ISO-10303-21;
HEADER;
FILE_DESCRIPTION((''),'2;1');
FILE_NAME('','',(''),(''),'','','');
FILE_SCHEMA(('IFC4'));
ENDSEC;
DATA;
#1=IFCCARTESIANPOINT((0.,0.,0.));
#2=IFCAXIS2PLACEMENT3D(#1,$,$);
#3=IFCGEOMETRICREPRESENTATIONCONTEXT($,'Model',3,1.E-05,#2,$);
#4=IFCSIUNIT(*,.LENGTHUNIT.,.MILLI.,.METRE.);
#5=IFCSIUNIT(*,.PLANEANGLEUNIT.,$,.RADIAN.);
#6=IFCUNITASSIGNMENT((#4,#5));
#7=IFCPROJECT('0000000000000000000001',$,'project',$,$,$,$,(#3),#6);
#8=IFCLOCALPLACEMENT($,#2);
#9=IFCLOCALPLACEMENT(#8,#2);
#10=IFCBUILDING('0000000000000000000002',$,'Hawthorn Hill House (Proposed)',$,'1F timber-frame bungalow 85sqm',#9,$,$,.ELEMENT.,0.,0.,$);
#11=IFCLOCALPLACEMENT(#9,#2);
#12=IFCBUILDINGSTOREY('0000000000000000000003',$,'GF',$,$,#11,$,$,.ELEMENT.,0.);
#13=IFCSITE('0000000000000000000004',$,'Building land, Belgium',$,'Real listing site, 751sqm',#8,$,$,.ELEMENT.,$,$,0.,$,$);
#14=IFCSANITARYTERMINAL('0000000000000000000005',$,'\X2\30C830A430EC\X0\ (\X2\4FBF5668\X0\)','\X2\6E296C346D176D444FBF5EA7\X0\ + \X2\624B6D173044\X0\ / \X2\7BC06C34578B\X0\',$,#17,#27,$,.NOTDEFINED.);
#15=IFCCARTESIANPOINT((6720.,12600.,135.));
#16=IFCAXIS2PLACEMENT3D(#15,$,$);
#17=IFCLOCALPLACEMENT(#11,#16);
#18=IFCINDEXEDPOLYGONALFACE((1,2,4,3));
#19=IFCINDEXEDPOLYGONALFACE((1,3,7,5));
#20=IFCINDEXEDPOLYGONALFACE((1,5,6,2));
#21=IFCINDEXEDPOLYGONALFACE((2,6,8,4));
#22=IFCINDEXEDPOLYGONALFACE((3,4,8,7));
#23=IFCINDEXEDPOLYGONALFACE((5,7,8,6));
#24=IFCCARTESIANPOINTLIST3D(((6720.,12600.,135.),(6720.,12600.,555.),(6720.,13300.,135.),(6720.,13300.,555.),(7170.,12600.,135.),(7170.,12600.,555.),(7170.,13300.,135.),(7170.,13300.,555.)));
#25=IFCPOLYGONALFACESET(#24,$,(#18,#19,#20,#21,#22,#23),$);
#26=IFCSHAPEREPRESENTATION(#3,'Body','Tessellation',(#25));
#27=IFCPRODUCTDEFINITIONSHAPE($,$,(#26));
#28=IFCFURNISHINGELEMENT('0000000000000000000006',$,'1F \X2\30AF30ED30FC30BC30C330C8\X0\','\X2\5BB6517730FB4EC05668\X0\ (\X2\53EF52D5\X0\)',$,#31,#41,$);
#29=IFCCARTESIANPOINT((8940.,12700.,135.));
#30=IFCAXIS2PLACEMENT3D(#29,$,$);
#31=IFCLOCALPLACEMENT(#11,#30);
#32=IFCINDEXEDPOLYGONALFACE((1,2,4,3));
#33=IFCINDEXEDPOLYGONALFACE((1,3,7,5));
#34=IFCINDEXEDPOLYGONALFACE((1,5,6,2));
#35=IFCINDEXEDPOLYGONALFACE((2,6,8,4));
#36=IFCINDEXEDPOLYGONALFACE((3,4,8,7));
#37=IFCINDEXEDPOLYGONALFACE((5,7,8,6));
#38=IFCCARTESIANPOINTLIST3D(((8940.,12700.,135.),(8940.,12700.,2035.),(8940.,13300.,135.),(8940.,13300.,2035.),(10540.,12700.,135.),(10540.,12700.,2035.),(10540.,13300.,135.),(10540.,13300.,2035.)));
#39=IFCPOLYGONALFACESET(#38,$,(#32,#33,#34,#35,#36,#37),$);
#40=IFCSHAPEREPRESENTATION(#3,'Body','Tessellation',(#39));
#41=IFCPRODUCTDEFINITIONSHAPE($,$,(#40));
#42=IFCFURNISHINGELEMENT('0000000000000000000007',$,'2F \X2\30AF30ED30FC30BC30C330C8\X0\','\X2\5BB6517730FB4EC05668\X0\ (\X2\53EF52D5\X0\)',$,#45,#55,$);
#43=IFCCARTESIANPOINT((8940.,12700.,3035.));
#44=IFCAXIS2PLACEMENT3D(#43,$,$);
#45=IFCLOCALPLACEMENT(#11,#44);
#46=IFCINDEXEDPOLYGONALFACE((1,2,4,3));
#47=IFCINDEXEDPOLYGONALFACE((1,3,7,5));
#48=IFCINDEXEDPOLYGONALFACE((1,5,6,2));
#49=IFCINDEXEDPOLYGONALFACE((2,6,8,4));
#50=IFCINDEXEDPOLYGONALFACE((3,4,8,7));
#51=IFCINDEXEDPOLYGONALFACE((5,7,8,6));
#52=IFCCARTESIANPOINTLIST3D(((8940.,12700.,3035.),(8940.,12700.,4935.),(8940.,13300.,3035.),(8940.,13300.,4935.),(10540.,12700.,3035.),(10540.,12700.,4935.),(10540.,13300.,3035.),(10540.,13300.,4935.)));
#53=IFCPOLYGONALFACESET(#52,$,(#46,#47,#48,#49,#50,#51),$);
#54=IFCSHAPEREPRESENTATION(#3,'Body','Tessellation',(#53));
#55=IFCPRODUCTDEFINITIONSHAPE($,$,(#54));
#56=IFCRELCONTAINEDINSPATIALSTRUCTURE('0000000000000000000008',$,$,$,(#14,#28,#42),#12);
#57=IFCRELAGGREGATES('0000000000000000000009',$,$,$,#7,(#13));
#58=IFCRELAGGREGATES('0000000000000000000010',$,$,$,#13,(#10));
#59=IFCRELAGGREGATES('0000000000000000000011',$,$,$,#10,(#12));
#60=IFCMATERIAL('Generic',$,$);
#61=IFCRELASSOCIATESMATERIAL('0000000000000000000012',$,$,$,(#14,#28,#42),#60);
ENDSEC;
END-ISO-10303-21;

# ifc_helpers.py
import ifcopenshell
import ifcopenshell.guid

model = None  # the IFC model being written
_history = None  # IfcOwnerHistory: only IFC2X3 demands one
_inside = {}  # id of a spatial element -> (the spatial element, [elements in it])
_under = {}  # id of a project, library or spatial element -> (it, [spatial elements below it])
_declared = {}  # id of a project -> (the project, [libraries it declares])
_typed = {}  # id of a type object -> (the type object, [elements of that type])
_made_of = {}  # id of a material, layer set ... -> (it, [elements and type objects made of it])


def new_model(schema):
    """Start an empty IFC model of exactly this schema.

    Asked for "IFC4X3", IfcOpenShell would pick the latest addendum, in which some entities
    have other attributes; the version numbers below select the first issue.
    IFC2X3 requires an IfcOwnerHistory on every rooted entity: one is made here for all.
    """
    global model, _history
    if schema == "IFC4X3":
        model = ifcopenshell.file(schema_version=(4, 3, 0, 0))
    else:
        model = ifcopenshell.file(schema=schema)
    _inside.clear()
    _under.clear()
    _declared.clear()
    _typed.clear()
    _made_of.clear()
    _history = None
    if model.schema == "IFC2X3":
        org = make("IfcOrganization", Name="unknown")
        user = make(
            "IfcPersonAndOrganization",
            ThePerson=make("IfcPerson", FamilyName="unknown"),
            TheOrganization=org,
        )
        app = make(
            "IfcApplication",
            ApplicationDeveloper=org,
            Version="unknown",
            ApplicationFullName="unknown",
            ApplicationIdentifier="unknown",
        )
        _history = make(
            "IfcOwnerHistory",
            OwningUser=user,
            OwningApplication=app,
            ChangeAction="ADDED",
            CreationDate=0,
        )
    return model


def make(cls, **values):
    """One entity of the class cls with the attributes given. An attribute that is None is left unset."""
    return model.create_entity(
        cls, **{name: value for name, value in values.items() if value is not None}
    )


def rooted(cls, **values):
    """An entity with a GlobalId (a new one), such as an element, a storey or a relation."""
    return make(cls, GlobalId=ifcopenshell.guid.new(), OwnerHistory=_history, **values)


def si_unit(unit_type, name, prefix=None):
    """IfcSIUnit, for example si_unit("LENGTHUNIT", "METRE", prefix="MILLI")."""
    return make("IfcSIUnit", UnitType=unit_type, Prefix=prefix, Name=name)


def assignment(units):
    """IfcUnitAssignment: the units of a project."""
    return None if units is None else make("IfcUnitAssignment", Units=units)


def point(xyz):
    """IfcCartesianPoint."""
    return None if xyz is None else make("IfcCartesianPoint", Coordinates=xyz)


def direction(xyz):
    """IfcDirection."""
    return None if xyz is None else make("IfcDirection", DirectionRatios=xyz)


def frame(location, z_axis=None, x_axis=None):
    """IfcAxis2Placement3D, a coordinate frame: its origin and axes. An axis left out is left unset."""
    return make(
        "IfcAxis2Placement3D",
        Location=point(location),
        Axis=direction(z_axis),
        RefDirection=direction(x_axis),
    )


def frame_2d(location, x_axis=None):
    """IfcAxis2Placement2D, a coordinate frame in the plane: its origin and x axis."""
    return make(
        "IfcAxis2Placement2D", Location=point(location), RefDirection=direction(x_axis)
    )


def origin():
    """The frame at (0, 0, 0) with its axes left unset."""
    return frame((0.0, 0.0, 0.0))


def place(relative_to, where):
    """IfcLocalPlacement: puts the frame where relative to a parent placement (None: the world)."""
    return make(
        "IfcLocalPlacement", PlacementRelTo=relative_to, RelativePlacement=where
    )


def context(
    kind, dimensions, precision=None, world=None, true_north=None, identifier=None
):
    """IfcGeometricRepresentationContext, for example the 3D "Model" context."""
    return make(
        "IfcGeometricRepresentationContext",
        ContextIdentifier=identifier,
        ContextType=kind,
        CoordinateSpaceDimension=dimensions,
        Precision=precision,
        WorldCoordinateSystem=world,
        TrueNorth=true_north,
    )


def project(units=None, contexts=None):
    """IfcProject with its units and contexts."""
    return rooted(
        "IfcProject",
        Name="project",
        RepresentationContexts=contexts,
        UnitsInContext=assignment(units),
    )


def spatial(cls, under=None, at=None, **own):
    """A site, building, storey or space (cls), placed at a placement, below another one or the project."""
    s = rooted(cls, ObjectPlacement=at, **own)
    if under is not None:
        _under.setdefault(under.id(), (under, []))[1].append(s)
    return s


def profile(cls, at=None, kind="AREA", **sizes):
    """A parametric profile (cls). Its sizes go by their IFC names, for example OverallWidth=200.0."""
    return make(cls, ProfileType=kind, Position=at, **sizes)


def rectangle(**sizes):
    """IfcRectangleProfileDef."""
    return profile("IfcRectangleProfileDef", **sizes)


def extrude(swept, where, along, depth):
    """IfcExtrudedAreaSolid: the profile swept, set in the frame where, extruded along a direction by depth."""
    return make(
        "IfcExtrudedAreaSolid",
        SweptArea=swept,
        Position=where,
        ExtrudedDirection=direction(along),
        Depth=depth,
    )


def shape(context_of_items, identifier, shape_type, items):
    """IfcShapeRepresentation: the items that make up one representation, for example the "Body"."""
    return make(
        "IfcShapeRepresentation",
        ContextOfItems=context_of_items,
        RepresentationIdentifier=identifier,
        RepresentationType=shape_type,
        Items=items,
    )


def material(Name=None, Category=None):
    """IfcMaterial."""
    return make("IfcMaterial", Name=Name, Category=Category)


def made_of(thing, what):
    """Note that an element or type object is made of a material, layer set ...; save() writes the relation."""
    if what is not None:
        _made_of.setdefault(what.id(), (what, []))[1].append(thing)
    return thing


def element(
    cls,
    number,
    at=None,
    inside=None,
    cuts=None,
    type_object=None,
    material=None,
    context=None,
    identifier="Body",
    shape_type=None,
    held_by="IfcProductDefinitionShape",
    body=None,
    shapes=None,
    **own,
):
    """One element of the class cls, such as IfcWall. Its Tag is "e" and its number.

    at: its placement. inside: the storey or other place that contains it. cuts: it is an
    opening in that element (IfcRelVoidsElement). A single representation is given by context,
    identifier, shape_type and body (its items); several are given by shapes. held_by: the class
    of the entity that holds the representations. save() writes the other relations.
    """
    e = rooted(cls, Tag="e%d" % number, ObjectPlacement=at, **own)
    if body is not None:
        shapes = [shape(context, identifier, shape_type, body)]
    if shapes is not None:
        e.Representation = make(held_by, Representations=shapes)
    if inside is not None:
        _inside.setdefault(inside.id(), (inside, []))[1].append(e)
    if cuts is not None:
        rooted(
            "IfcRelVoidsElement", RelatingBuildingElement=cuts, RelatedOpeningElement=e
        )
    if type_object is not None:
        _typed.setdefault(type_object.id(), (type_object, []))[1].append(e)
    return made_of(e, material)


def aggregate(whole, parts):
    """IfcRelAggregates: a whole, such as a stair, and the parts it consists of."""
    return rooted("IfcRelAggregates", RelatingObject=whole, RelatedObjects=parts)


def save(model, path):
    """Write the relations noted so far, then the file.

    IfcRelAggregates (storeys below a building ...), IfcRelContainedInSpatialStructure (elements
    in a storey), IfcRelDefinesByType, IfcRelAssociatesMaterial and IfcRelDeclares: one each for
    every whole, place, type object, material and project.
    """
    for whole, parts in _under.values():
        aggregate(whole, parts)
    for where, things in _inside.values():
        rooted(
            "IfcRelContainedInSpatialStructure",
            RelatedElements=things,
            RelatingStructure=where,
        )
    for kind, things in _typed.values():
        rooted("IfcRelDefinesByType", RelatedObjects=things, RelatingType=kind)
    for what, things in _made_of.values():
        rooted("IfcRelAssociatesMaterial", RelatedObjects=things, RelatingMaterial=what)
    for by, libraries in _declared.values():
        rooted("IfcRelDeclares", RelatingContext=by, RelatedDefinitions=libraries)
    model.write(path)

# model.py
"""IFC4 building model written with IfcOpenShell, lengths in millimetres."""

from ifc_helpers import new_model, si_unit, frame, frame_2d, origin, place, context, project, spatial, rectangle, extrude, material, element, save


model = new_model("IFC4")

# Units and contexts
model_context = context("Model", 3, precision=1e-05, world=origin())
ifc_project = project(units=[si_unit("LENGTHUNIT", "METRE", prefix="MILLI"), si_unit("PLANEANGLEUNIT", "RADIAN")], contexts=[model_context])

# Site, building, storey
site_placement = place(None, origin())
site = spatial("IfcSite", under=ifc_project, at=site_placement, Name="Building land, Belgium", ObjectType="Real listing site, 751sqm", CompositionType="ELEMENT", RefElevation=0.0)
building_placement = place(site_placement, origin())
building = spatial("IfcBuilding", under=site, at=building_placement, Name="Hawthorn Hill House (Proposed)", ObjectType="1F timber-frame bungalow 85sqm", CompositionType="ELEMENT", ElevationOfRefHeight=0.0, ElevationOfTerrain=0.0)
storey_placement = place(building_placement, origin())
storey = spatial("IfcBuildingStorey", under=building, at=storey_placement, Name="GF", CompositionType="ELEMENT", Elevation=0.0)

# Sanitary terminal
ifc_material_1 = material(Name="Generic")
sanitary_terminal_1_placement = place(storey_placement, frame((6720.0, 12600.0, 135.0)))
element("IfcSanitaryTerminal", 1, at=sanitary_terminal_1_placement, inside=storey, material=ifc_material_1, Name="トイレ (便器)", Description="温水洗浄便座 + 手洗い / 節水型", PredefinedType="NOTDEFINED", context=model_context, shape_type="SweptSolid", body=[
    extrude(rectangle(XDim=450.0, YDim=700.0, at=frame_2d((225.0, 350.0))), frame((6720.0, 12600.0, 135.0)), (0.0, 0.0, 1.0), 420.0),
])

# Furnishing elements
furnishing_1_placement = place(storey_placement, frame((8940.0, 12700.0, 135.0)))
element("IfcFurnishingElement", 2, at=furnishing_1_placement, inside=storey, material=ifc_material_1, Name="1F クローゼット", Description="家具・什器 (可動)", context=model_context, shape_type="SweptSolid", body=[
    extrude(rectangle(XDim=1600.0, YDim=600.0, at=frame_2d((800.0, 300.0))), frame((8940.0, 12700.0, 135.0)), (0.0, 0.0, 1.0), 1900.0),
])
furnishing_2_placement = place(storey_placement, frame((8940.0, 12700.0, 3035.0)))
element("IfcFurnishingElement", 3, at=furnishing_2_placement, inside=storey, material=ifc_material_1, Name="2F クローゼット", Description="家具・什器 (可動)", context=model_context, shape_type="SweptSolid", body=[
    extrude(rectangle(XDim=1600.0, YDim=600.0, at=frame_2d((800.0, 300.0))), frame((8940.0, 12700.0, 3035.0)), (0.0, 0.0, 1.0), 1900.0),
])

save(model, "model.ifc")
